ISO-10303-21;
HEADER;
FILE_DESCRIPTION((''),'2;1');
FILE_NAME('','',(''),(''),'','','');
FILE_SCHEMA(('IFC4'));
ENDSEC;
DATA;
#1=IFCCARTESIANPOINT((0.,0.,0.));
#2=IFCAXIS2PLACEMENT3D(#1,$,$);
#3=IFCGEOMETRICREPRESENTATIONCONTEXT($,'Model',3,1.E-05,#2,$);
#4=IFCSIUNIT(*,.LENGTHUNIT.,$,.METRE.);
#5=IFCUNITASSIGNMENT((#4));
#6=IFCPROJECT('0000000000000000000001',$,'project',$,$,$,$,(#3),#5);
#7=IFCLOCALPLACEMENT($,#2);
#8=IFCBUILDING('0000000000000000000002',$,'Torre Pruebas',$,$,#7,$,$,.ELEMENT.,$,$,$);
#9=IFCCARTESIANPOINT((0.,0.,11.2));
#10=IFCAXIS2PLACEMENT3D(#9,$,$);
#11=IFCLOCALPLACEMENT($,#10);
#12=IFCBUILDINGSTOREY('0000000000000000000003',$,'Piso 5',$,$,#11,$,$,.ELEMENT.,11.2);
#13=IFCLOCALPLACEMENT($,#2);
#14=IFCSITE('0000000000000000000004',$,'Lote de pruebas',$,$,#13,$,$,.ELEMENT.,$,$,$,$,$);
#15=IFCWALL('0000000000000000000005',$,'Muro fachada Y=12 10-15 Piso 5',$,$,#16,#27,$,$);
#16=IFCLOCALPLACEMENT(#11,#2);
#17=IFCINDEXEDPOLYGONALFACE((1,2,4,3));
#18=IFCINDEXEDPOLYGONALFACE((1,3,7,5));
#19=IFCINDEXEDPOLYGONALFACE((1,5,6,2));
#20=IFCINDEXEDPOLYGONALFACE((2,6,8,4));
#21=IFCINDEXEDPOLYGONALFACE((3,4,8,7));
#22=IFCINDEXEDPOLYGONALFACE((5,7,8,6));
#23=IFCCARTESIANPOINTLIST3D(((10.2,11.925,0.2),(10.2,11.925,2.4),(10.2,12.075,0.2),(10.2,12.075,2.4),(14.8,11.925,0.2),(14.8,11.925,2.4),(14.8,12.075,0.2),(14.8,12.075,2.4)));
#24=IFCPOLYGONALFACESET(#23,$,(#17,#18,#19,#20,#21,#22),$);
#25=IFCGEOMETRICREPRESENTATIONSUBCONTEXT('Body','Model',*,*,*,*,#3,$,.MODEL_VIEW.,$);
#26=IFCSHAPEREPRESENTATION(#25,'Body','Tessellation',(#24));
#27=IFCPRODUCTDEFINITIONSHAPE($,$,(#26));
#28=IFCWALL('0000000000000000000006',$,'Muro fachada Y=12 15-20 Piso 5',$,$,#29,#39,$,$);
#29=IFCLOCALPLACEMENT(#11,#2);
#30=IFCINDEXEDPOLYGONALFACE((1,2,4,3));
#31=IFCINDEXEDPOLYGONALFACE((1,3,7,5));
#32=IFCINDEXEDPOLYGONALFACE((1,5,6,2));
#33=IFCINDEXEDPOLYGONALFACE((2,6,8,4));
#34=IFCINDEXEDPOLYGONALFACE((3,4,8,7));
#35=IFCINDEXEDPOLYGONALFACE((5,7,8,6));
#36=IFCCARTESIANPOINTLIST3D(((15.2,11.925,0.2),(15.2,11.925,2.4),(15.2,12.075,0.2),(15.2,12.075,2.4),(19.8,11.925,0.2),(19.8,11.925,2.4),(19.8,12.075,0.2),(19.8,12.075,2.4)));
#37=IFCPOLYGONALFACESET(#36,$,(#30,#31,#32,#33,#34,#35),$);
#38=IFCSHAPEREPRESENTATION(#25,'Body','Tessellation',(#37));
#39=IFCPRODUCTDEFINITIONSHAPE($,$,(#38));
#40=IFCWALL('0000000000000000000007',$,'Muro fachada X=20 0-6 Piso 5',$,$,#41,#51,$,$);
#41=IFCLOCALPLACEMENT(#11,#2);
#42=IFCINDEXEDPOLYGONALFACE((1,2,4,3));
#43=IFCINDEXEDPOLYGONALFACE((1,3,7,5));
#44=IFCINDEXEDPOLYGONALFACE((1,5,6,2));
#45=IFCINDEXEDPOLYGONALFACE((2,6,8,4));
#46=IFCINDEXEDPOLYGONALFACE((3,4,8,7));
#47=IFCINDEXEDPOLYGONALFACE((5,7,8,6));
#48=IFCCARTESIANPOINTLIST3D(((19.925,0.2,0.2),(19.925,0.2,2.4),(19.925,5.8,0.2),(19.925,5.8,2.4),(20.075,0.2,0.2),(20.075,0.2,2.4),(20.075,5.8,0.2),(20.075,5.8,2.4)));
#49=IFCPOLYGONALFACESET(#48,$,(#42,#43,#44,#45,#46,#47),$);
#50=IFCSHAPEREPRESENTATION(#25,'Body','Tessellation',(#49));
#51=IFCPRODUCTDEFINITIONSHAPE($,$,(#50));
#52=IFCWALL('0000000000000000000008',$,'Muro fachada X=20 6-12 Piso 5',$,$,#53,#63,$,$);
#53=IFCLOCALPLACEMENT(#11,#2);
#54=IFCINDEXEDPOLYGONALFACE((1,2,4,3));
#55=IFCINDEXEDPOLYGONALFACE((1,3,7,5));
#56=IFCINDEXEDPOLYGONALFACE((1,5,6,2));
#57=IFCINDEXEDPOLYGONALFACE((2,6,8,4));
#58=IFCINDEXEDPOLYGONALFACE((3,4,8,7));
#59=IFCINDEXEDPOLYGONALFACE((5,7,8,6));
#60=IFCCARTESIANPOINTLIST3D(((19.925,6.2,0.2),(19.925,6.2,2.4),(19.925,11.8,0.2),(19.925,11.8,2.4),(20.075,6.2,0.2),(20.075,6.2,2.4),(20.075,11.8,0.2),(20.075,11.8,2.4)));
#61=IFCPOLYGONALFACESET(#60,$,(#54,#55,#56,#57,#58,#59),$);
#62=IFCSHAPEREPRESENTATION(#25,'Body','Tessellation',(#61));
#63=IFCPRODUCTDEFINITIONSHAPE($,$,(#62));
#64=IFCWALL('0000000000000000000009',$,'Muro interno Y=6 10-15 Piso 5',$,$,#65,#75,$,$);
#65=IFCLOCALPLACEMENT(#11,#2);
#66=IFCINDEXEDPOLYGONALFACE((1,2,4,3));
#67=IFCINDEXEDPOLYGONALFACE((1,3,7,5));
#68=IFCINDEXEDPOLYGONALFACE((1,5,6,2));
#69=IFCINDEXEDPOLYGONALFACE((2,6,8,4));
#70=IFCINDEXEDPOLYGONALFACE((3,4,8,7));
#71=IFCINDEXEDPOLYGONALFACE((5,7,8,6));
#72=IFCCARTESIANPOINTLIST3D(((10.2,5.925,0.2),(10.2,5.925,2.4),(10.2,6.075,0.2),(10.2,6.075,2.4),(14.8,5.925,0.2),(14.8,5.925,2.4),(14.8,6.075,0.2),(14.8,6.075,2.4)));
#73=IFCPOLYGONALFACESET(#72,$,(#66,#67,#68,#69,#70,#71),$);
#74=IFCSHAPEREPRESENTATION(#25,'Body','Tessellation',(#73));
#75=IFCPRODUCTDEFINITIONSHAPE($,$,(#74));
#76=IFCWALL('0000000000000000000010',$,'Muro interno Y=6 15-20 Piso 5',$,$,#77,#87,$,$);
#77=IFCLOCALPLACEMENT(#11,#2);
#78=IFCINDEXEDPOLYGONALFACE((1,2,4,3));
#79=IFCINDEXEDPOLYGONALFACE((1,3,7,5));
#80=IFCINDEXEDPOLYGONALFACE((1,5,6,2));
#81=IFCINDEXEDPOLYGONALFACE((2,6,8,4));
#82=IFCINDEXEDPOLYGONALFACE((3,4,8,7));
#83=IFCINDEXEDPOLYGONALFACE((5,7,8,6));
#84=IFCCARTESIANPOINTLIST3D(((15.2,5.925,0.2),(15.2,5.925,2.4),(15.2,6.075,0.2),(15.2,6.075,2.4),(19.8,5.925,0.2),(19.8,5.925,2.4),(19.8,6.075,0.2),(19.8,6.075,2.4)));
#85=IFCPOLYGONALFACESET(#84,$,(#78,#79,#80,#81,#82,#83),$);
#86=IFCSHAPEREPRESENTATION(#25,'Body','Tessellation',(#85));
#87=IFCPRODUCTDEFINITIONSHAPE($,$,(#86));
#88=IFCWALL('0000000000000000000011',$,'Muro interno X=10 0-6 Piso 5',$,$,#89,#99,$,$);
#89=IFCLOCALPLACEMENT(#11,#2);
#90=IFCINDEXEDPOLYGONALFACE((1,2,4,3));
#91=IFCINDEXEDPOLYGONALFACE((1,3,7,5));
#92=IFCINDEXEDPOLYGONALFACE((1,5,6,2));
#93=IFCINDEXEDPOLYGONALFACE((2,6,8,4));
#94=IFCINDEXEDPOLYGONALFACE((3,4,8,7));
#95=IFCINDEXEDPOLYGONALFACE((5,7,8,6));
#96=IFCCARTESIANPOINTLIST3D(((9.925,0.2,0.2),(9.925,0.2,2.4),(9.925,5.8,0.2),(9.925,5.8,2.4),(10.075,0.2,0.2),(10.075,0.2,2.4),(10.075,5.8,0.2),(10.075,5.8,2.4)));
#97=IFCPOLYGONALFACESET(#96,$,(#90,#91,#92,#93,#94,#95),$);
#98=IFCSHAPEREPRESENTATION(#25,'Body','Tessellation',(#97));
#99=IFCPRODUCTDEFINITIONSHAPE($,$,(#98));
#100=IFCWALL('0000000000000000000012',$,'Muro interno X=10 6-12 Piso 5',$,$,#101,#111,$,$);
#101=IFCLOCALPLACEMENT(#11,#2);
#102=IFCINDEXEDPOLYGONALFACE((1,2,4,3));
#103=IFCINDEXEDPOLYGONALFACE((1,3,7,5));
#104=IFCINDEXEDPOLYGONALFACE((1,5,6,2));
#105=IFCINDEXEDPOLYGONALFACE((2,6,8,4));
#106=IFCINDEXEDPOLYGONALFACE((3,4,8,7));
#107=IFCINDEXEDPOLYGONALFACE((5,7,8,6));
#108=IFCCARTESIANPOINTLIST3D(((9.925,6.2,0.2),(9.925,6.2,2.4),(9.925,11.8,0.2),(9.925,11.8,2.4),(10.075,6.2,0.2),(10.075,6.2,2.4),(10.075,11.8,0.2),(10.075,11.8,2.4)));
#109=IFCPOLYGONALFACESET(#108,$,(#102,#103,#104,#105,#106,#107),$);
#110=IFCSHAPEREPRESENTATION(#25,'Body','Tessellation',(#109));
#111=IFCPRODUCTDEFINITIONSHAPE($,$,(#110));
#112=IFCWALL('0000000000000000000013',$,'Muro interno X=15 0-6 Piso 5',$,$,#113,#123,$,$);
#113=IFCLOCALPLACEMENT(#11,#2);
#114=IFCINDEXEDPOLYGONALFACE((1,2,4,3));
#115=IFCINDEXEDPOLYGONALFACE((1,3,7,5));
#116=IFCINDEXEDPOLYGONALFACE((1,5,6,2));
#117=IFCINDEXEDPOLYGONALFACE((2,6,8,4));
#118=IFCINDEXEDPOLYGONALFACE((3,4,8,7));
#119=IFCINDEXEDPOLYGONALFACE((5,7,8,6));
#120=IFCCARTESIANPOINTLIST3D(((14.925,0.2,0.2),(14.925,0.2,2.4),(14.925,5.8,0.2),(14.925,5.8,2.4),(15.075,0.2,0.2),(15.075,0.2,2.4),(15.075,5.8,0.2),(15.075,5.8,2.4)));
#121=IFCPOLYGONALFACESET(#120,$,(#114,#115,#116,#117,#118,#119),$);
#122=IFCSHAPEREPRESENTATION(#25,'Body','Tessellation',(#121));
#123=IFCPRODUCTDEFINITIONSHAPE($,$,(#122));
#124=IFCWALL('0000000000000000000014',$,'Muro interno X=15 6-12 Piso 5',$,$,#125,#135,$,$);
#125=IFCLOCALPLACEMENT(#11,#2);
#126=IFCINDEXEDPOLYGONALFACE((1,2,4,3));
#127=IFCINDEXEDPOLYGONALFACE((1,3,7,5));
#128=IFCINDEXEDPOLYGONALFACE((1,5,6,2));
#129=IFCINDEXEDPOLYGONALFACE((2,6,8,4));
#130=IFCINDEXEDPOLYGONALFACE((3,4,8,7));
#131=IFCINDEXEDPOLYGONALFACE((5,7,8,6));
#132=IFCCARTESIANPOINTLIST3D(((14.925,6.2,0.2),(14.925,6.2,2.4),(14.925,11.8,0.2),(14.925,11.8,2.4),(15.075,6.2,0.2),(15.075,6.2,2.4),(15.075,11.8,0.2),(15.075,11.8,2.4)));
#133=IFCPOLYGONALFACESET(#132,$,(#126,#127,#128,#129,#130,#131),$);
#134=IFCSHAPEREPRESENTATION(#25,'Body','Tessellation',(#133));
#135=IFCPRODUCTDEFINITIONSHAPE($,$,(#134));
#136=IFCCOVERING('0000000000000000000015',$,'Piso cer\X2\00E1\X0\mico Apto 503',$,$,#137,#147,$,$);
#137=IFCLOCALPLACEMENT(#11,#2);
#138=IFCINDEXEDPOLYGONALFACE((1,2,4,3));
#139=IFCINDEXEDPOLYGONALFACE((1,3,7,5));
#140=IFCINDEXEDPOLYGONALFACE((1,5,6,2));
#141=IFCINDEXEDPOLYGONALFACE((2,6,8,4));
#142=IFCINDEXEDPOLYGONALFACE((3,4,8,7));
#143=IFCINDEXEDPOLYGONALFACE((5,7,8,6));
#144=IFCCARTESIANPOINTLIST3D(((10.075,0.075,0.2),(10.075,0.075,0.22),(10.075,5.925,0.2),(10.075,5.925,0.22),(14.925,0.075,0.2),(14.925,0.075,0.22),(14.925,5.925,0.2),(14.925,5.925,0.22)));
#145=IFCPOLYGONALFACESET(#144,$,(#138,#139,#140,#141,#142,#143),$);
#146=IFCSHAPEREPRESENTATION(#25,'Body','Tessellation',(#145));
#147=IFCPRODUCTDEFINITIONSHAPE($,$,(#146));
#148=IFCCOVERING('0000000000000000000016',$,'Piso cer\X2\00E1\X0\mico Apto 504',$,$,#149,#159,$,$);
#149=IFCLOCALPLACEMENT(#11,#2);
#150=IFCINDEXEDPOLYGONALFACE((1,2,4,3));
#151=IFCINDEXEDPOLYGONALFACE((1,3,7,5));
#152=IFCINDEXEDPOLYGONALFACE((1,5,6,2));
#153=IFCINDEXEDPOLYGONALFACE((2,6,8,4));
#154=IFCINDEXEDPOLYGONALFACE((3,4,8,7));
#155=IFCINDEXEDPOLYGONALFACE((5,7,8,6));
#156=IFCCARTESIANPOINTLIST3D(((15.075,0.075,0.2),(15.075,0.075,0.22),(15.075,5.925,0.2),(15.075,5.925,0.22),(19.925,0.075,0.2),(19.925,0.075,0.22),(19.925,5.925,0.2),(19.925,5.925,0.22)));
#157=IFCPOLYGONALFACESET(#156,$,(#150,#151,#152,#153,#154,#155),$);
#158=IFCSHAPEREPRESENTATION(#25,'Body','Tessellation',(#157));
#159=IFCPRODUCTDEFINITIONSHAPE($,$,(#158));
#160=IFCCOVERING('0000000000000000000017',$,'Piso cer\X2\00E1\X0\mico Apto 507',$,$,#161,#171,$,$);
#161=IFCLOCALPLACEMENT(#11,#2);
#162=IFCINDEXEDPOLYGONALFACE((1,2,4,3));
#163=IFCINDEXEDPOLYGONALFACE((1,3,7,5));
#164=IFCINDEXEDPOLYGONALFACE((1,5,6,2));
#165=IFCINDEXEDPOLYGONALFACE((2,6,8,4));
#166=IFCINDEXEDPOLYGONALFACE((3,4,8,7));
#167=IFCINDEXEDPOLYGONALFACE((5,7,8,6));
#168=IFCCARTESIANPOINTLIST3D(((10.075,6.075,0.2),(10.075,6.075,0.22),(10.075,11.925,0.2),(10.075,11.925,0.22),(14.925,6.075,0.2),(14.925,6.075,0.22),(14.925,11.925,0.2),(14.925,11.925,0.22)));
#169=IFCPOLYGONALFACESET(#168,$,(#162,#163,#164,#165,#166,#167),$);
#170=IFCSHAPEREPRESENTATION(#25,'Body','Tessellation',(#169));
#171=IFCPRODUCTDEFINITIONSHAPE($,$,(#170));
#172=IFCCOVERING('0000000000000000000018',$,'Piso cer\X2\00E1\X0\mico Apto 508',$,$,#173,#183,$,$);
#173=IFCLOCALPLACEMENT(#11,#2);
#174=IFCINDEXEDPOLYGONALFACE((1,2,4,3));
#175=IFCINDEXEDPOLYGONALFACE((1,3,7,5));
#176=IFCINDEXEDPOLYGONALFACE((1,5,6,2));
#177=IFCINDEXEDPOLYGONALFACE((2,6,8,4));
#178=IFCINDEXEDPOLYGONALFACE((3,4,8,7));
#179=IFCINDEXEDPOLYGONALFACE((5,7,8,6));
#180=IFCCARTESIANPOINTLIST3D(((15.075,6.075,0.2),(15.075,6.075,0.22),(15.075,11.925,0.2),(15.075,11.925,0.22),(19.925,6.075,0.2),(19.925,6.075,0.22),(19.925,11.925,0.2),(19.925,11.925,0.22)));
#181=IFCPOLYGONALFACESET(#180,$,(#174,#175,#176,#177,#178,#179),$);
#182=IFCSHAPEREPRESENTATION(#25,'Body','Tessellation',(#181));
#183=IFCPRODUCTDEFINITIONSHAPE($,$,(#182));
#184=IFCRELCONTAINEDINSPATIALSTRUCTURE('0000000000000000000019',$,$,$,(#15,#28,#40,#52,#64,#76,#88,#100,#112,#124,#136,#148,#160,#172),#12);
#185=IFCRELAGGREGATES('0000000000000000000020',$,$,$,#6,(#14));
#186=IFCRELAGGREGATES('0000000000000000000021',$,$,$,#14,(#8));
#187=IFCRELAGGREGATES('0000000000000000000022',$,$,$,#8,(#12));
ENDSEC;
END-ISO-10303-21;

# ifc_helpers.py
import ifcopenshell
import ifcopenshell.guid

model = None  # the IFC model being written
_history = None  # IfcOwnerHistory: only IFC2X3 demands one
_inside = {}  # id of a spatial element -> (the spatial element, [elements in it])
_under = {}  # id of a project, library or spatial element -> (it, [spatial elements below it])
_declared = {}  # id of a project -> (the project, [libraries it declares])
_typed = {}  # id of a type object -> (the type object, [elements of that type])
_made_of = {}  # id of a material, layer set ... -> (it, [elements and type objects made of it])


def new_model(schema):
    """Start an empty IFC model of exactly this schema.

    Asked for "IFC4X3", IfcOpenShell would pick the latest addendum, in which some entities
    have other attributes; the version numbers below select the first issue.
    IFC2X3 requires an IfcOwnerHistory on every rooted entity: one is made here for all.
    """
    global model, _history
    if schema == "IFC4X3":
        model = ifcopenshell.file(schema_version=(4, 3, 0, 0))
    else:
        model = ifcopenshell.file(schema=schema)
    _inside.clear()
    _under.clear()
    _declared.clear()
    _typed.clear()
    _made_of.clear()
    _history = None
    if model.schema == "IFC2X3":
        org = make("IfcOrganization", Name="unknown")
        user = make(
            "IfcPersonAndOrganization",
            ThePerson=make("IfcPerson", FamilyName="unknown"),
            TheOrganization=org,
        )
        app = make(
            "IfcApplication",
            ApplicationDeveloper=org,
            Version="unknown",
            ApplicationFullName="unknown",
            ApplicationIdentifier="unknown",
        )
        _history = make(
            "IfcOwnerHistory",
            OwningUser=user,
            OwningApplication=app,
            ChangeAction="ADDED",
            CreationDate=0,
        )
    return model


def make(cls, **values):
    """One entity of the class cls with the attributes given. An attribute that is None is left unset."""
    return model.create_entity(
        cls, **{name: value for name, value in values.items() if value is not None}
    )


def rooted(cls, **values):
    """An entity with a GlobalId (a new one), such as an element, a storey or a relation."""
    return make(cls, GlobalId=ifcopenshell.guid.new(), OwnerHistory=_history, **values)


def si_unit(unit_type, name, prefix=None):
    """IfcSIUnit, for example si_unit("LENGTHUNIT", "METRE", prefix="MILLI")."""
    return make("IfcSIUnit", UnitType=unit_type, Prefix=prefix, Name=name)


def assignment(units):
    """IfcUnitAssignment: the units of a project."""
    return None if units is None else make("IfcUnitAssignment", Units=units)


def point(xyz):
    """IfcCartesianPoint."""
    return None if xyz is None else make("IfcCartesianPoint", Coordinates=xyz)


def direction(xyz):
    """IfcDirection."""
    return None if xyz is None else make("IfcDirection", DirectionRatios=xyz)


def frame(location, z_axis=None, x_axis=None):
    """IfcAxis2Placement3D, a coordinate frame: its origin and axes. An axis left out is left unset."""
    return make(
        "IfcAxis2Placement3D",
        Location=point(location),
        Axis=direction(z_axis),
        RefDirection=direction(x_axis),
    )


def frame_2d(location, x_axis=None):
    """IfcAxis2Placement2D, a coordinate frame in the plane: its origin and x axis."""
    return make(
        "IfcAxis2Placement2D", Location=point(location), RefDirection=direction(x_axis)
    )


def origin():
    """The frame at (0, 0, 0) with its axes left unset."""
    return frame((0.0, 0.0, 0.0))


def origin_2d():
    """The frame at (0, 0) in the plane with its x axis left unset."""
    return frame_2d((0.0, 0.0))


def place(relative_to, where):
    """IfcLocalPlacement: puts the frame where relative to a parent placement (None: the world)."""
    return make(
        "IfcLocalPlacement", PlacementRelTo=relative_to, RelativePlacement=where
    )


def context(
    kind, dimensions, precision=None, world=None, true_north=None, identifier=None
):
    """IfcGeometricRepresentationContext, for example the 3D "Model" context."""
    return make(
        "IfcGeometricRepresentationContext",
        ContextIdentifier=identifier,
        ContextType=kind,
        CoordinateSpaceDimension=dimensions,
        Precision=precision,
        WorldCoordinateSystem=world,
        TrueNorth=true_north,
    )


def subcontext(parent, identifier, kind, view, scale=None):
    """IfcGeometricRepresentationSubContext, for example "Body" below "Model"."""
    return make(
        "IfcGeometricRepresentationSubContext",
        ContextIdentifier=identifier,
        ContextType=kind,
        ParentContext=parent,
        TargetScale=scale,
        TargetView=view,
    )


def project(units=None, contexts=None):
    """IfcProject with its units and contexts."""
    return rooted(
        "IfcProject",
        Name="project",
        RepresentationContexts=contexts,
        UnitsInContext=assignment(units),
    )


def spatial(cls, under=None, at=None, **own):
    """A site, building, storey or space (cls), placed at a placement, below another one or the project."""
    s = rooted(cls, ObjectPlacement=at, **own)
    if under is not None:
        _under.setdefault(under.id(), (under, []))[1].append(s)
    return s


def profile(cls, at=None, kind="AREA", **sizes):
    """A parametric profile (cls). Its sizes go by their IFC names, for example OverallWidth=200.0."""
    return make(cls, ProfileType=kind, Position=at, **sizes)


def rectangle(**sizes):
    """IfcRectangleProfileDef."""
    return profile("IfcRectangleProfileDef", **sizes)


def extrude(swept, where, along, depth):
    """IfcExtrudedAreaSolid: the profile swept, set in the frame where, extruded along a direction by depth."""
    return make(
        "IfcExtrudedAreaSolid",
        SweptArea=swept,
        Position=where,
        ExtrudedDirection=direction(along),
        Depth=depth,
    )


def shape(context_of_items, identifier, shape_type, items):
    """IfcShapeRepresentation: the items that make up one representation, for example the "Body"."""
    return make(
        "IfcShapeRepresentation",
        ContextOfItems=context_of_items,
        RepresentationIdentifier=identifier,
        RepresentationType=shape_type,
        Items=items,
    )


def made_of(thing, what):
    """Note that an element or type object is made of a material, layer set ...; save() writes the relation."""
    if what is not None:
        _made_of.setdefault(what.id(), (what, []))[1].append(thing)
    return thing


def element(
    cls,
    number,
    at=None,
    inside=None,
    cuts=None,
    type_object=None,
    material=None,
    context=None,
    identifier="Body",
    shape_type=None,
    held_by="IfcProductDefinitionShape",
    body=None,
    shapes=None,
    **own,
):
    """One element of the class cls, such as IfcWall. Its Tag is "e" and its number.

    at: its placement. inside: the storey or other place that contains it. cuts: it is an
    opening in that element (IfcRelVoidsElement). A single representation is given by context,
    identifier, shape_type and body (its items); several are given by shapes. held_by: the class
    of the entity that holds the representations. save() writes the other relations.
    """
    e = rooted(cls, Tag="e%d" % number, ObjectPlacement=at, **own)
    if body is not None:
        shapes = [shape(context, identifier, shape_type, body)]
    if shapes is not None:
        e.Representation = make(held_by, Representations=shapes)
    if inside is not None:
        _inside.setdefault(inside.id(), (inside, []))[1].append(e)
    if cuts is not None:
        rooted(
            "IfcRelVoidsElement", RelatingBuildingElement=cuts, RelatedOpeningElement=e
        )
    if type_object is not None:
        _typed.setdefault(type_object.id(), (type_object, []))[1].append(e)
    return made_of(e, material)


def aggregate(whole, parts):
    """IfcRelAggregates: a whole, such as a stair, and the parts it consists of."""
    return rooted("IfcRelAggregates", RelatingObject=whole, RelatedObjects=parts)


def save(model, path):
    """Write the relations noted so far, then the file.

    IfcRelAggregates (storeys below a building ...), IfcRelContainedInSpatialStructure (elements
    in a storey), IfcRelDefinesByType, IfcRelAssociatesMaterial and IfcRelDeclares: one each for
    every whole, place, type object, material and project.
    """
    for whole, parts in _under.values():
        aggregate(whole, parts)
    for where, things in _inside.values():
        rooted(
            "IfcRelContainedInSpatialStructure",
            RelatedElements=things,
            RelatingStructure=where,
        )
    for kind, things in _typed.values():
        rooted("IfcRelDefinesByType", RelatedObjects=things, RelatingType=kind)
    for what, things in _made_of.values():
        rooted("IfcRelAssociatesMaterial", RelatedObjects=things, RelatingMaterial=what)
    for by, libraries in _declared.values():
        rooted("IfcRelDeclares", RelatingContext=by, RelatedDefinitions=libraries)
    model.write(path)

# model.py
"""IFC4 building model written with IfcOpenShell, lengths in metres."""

from ifc_helpers import new_model, si_unit, frame, origin, origin_2d, place, context, subcontext, project, spatial, rectangle, extrude, element, save


model = new_model("IFC4")

# Units and contexts
model_context = context("Model", 3, precision=1e-05, world=origin())
body_context = subcontext(model_context, "Body", "Model", "MODEL_VIEW")
ifc_project = project(units=[si_unit("LENGTHUNIT", "METRE")], contexts=[model_context])

# Site, building, storey
site_placement = place(None, origin())
site = spatial("IfcSite", under=ifc_project, at=site_placement, Name="Lote de pruebas", CompositionType="ELEMENT")
building_placement = place(None, origin())
building = spatial("IfcBuilding", under=site, at=building_placement, Name="Torre Pruebas", CompositionType="ELEMENT")
storey_placement = place(None, frame((0.0, 0.0, 11.2)))
storey = spatial("IfcBuildingStorey", under=building, at=storey_placement, Name="Piso 5", CompositionType="ELEMENT", Elevation=11.2)

# Walls
for number, where, name in (
    (1, (12.5, 12.0, 11.4), "Muro fachada Y=12 10-15 Piso 5"),
    (2, (17.5, 12.0, 11.4), "Muro fachada Y=12 15-20 Piso 5"),
):
    element("IfcWall", number, at=place(None, frame(where)), inside=storey, Name=name, context=body_context, shape_type="SweptSolid", body=[
        extrude(rectangle(XDim=4.6, YDim=0.15, at=origin_2d()), origin(), (0.0, 0.0, 1.0), 2.2),
    ])
for number, where, name in (
    (3, (20.0, 3.0, 11.4), "Muro fachada X=20 0-6 Piso 5"),
    (4, (20.0, 9.0, 11.4), "Muro fachada X=20 6-12 Piso 5"),
):
    element("IfcWall", number, at=place(None, frame(where)), inside=storey, Name=name, context=body_context, shape_type="SweptSolid", body=[
        extrude(rectangle(XDim=0.15, YDim=5.6, at=origin_2d()), origin(), (0.0, 0.0, 1.0), 2.2),
    ])
for number, where, name in (
    (5, (12.5, 6.0, 11.4), "Muro interno Y=6 10-15 Piso 5"),
    (6, (17.5, 6.0, 11.4), "Muro interno Y=6 15-20 Piso 5"),
):
    element("IfcWall", number, at=place(None, frame(where)), inside=storey, Name=name, context=body_context, shape_type="SweptSolid", body=[
        extrude(rectangle(XDim=4.6, YDim=0.15, at=origin_2d()), origin(), (0.0, 0.0, 1.0), 2.2),
    ])
for number, where, name in (
    (7, (10.0, 3.0, 11.4), "Muro interno X=10 0-6 Piso 5"),
    (8, (10.0, 9.0, 11.4), "Muro interno X=10 6-12 Piso 5"),
    (9, (15.0, 3.0, 11.4), "Muro interno X=15 0-6 Piso 5"),
    (10, (15.0, 9.0, 11.4), "Muro interno X=15 6-12 Piso 5"),
):
    element("IfcWall", number, at=place(None, frame(where)), inside=storey, Name=name, context=body_context, shape_type="SweptSolid", body=[
        extrude(rectangle(XDim=0.15, YDim=5.6, at=origin_2d()), origin(), (0.0, 0.0, 1.0), 2.2),
    ])

# Coverings
for number, where, name in (
    (11, (12.5, 3.0, 11.4), "Piso cerámico Apto 503"),
    (12, (17.5, 3.0, 11.4), "Piso cerámico Apto 504"),
    (13, (12.5, 9.0, 11.4), "Piso cerámico Apto 507"),
    (14, (17.5, 9.0, 11.4), "Piso cerámico Apto 508"),
):
    element("IfcCovering", number, at=place(None, frame(where)), inside=storey, Name=name, context=body_context, shape_type="SweptSolid", body=[
        extrude(rectangle(XDim=4.85, YDim=5.85, at=origin_2d()), origin(), (0.0, 0.0, 1.0), 0.02),
    ])

save(model, "model.ifc")
